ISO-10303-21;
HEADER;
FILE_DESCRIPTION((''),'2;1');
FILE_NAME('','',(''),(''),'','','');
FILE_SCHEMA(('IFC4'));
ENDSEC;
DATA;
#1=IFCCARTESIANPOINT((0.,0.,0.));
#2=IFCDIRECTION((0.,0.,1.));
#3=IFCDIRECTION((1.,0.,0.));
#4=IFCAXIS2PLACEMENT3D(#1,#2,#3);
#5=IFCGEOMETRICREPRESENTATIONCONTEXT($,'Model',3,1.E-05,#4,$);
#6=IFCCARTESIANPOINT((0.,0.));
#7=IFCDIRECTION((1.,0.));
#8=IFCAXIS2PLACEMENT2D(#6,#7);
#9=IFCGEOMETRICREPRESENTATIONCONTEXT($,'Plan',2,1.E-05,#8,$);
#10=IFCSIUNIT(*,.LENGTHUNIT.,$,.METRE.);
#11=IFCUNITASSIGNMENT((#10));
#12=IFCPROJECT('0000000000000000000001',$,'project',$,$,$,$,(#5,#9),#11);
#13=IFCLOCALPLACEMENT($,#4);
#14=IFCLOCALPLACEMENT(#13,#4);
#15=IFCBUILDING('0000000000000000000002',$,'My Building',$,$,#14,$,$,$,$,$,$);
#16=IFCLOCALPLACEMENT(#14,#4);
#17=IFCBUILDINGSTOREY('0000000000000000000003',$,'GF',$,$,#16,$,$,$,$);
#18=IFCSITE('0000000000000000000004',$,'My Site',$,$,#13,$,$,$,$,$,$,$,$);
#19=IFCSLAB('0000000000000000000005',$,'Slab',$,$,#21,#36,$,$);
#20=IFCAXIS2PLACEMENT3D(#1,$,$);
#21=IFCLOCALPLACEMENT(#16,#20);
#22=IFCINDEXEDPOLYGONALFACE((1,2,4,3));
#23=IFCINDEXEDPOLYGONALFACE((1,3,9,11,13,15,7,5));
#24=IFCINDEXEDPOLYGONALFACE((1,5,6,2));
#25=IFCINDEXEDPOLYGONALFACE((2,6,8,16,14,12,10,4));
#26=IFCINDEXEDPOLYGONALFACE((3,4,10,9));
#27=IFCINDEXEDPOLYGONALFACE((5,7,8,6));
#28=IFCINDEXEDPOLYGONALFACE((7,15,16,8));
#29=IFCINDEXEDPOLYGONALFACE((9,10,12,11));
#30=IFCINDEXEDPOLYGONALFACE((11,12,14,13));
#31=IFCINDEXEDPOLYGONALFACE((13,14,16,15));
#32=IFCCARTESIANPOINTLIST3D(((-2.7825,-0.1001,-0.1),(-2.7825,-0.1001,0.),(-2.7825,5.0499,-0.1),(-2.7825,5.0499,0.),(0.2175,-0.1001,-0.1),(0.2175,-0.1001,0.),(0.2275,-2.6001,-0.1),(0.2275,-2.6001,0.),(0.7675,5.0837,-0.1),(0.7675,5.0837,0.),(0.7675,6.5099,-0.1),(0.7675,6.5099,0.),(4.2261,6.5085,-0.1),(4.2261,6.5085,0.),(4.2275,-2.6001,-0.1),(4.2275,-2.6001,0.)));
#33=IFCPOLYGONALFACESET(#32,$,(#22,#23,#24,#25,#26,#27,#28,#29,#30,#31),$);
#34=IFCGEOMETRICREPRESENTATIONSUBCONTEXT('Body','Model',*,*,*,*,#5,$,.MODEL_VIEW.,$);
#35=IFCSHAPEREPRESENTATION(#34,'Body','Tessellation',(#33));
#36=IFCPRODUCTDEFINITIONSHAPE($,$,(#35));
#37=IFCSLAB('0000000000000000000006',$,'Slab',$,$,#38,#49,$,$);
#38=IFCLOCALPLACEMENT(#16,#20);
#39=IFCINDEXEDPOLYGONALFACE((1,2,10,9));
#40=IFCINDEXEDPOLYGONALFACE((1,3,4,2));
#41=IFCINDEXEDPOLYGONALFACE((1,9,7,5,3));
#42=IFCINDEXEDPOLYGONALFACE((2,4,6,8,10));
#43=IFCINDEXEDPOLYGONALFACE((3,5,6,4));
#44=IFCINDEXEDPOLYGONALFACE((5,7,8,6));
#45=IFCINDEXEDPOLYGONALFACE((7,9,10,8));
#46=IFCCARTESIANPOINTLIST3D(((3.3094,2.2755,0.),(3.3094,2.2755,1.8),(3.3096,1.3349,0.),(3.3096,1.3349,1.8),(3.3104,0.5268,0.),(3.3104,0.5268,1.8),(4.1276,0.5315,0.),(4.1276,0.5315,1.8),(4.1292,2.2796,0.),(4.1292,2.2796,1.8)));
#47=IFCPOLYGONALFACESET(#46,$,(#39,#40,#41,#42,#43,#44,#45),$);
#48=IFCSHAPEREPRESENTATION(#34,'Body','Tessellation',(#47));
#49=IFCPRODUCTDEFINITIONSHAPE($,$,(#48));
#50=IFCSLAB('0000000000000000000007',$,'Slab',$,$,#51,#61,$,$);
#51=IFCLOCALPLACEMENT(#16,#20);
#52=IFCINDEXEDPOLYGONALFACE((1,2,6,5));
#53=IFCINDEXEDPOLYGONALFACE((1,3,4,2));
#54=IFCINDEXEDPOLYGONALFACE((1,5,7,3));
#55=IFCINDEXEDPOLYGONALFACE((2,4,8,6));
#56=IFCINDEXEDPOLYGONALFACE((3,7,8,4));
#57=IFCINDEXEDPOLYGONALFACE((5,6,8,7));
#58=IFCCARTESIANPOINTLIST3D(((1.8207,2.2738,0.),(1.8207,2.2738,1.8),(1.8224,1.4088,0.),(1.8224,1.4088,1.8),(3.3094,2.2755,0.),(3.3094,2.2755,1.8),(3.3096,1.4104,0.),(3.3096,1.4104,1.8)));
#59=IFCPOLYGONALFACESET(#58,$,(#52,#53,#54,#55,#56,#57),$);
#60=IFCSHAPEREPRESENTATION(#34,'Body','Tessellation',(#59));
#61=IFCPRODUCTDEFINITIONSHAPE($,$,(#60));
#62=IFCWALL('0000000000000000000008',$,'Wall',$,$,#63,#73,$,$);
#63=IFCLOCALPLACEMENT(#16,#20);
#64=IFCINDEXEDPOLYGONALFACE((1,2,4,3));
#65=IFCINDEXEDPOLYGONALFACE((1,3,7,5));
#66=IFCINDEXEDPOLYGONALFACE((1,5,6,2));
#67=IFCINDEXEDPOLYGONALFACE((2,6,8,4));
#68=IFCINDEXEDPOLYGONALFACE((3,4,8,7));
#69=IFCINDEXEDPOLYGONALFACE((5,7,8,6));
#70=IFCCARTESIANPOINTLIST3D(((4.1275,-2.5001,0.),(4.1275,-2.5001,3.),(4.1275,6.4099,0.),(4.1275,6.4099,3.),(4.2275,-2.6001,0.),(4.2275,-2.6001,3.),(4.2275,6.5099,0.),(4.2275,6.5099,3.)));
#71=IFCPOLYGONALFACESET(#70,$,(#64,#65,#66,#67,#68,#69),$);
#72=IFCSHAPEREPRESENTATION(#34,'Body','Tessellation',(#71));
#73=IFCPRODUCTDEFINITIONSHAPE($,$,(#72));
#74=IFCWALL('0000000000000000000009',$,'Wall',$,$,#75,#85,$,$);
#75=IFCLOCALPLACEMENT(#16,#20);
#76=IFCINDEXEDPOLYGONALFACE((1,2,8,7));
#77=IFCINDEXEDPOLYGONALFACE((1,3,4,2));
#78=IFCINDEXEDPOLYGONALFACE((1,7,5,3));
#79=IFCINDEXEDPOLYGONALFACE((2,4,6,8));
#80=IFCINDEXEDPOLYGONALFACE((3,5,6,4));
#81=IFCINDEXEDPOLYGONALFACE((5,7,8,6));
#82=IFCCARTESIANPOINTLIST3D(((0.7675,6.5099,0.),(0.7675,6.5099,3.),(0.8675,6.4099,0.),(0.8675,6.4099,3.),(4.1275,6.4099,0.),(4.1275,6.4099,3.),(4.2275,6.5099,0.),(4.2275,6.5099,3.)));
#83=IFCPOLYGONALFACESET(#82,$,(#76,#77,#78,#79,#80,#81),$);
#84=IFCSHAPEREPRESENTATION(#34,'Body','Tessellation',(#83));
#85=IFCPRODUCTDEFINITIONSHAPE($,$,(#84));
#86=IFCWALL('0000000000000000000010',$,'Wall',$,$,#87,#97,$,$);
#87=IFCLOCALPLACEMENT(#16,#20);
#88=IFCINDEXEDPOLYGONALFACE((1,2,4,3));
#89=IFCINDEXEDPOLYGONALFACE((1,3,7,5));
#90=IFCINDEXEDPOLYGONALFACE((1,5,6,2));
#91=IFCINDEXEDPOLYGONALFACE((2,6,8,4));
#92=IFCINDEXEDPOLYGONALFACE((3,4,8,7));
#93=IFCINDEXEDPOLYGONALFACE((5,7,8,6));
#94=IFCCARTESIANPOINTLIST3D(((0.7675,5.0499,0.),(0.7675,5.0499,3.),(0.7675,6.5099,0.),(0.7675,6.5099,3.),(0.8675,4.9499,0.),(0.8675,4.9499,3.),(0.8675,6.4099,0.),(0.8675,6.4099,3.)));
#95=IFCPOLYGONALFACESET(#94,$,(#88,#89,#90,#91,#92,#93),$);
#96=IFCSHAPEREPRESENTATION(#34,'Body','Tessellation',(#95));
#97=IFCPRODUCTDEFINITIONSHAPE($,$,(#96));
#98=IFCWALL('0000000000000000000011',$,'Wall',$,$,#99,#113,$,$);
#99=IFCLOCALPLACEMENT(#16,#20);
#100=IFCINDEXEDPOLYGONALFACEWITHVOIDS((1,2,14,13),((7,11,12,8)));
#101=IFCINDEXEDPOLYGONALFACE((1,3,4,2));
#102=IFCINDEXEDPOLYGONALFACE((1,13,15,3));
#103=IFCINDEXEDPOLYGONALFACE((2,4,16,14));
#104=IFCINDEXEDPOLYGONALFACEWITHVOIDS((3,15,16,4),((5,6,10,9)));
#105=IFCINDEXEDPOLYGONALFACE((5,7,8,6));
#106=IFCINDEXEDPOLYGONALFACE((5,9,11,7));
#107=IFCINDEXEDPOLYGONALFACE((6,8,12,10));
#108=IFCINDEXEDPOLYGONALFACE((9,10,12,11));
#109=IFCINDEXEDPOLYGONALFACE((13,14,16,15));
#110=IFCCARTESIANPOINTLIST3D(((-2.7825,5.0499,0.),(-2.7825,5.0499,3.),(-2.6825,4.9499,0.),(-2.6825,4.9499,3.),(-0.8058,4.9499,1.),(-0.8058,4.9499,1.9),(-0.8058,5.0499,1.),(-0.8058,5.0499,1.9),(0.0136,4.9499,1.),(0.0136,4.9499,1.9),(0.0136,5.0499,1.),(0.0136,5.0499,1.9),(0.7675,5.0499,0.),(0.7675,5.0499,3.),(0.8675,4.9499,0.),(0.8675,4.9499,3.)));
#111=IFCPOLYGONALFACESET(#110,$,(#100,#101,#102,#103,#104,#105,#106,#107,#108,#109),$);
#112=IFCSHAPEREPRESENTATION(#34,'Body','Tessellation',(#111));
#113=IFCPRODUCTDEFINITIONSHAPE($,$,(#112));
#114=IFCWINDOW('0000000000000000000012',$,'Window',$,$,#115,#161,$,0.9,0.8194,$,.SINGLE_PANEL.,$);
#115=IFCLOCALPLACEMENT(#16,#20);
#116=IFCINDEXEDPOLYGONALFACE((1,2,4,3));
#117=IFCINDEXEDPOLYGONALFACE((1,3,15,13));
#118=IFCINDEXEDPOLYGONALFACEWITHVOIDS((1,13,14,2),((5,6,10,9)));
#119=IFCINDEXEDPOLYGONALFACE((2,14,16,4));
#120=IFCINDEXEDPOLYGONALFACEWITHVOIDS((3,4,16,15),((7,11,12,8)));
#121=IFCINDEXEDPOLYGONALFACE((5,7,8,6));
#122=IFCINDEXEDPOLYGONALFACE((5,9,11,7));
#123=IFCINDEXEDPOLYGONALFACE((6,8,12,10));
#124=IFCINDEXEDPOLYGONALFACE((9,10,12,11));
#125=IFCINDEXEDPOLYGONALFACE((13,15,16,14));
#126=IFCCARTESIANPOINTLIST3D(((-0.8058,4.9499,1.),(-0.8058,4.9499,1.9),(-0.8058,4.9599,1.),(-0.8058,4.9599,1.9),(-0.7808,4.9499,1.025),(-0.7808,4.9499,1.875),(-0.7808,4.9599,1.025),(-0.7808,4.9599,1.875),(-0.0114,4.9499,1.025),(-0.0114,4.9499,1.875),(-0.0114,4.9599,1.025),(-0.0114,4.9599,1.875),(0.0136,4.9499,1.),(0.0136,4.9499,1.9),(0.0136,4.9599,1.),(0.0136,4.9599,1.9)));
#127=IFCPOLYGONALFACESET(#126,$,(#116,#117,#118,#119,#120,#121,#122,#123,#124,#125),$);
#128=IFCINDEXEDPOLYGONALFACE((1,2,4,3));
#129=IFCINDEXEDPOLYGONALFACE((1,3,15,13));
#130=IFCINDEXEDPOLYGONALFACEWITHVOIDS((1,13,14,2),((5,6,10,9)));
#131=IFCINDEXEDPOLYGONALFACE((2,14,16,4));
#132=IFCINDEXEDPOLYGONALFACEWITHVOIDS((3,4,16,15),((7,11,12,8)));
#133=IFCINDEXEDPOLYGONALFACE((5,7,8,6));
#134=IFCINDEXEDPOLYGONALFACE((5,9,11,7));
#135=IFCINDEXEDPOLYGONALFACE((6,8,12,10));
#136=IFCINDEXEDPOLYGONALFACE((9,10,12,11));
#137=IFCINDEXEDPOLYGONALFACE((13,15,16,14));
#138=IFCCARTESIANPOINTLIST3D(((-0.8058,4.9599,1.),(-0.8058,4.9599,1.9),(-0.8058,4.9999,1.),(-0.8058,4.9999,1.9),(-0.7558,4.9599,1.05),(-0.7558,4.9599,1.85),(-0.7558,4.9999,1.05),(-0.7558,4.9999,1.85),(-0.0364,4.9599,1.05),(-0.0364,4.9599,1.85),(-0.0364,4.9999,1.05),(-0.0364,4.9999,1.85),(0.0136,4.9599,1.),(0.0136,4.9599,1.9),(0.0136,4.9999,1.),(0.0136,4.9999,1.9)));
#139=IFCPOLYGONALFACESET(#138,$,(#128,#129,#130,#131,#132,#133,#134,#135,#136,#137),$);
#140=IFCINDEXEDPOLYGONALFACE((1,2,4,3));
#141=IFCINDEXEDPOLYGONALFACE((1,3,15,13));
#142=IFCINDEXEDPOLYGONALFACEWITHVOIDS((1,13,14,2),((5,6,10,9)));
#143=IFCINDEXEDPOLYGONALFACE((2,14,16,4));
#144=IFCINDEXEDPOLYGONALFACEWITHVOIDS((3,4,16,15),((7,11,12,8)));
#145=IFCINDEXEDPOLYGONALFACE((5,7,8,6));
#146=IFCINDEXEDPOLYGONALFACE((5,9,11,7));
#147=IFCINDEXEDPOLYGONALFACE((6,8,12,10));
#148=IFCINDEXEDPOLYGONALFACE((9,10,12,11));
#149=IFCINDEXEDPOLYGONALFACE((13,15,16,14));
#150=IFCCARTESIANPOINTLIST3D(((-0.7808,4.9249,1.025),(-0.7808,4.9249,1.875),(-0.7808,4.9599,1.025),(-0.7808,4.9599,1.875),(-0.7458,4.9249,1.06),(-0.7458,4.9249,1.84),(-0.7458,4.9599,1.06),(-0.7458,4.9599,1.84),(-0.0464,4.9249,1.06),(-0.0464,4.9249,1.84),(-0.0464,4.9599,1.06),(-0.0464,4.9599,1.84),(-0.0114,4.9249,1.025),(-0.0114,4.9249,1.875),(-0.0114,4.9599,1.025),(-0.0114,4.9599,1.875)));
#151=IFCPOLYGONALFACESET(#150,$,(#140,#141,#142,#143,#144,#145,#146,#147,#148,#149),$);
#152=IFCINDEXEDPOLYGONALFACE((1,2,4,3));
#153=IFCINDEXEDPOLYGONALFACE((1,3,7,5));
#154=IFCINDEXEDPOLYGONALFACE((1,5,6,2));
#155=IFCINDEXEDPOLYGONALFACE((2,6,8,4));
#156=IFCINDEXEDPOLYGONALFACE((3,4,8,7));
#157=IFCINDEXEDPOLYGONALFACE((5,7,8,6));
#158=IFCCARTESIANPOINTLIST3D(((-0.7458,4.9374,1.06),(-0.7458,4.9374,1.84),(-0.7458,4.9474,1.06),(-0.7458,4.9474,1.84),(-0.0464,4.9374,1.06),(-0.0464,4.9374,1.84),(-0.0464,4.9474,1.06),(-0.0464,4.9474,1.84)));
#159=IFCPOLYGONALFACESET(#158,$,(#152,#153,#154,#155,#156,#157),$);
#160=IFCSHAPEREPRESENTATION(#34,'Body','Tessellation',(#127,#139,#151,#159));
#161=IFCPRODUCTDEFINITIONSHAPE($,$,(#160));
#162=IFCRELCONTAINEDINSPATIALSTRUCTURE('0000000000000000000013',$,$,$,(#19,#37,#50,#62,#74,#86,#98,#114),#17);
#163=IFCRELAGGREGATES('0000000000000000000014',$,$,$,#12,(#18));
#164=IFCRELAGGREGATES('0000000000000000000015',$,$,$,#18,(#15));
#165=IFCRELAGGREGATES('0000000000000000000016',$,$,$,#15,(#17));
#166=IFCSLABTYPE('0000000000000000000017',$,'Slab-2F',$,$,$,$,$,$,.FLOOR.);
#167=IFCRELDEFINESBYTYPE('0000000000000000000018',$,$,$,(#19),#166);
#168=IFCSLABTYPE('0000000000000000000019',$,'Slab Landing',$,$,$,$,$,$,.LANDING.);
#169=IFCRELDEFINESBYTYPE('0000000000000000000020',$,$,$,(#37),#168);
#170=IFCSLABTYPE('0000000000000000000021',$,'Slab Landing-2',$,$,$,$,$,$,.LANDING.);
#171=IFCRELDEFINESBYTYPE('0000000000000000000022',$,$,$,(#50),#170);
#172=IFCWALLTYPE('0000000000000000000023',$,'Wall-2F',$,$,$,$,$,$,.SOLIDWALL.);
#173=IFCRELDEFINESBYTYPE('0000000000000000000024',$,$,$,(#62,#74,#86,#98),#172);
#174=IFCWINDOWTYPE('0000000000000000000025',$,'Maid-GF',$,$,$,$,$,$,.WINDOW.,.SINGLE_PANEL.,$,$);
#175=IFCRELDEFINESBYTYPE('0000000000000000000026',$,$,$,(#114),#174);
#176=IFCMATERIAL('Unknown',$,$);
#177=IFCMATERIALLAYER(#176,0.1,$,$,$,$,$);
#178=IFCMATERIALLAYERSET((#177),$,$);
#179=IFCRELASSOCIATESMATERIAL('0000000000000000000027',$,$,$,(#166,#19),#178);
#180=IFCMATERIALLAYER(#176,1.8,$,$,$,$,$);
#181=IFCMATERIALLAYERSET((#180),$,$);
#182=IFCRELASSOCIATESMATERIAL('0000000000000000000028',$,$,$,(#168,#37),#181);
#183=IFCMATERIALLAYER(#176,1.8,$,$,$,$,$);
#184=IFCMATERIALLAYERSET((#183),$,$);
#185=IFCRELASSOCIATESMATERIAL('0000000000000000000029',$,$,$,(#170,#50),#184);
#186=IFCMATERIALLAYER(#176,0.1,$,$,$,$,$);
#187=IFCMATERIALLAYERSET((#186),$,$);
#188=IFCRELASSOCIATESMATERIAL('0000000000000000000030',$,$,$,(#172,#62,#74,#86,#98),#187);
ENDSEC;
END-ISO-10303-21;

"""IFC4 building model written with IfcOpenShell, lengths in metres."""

from ifc_helpers import new_model, entity, si_unit, frame, origin_with_axes, origin_2d_with_axis, place, context, subcontext, project, spatial, line, indexed_curve, outline, extrude, shape, source, transform, mapped, material, layer, layer_set, layer_usage, type_object, type_shapes, element, fill, save


model = new_model("IFC4")

# Units and contexts
model_context = context("Model", 3, precision=1e-05, world=origin_with_axes())
plan_context = context("Plan", 2, precision=1e-05, world=origin_2d_with_axis())
body_context_1 = subcontext(model_context, "Body", "Model", "MODEL_VIEW")
body_context_2 = subcontext(plan_context, "Body", "Plan", "PLAN_VIEW")
ifc_project = project(units=[si_unit("LENGTHUNIT", "METRE")], contexts=[model_context, plan_context])

# Site, building, storey
site_placement = place(None, origin_with_axes())
site = spatial("IfcSite", under=ifc_project, at=site_placement, Name="My Site")
building_placement = place(site_placement, origin_with_axes())
building = spatial("IfcBuilding", under=site, at=building_placement, Name="My Building")
storey_placement = place(building_placement, origin_with_axes())
storey = spatial("IfcBuildingStorey", under=building, at=storey_placement, Name="GF")

# Slabs
ifc_material_1 = material(Name="Unknown")
ifc_layer_1 = layer(ifc_material_1, 0.1)
ifc_layer_set_1 = layer_set([ifc_layer_1])
ifc_layer_usage_1 = layer_usage(ifc_layer_set_1, "AXIS3", "POSITIVE", -0.1)
slab_type_1 = type_object("IfcSlabType", Name="Slab-2F", PredefinedType="FLOOR", material=ifc_layer_set_1)
slab_1_placement = place(storey_placement, frame((4.2275, -2.6001, 0.0), z_axis=(0.0, 0.0, 1.0), x_axis=(1.0, 0.0, 0.0)))
element("IfcSlab", 1, at=slab_1_placement, inside=storey, type_object=slab_type_1, material=ifc_layer_usage_1, Name="Slab", context=body_context_1, shape_type="SweptSolid", body=[
    extrude(outline(indexed_curve([(0.0, 0.0), (-0.0014, 9.1086), (-3.46, 9.11), (-3.46, 7.6838), (-7.01, 7.65), (-7.01, 2.5), (-4.01, 2.5), (-4.0, 0.0), (0.0, 0.0)])), frame((0.0, 0.0, -0.1), z_axis=(0.0, 0.0, 1.0), x_axis=(1.0, 0.0, 0.0)), (0.0, 0.0, 1.0), 0.1),
])
ifc_layer_2 = layer(ifc_material_1, 1.8)
ifc_layer_set_2 = layer_set([ifc_layer_2])
ifc_layer_usage_2 = layer_usage(ifc_layer_set_2, "AXIS3", "POSITIVE", -0.1)
slab_type_2 = type_object("IfcSlabType", Name="Slab Landing", PredefinedType="LANDING", material=ifc_layer_set_2)
slab_2_placement = place(storey_placement, frame((3.3096, 1.3349, 0.1), z_axis=(0.0, 0.0, 1.0), x_axis=(1.0, 0.0, 0.0)))
element("IfcSlab", 2, at=slab_2_placement, inside=storey, type_object=slab_type_2, material=ifc_layer_usage_2, Name="Slab", context=body_context_1, shape_type="SweptSolid", body=[
    extrude(outline(indexed_curve([(0.0, 0.0), (0.0008, -0.8081), (0.818, -0.8034), (0.8196, 0.9447), (-0.0002, 0.9407), (0.0, 0.0)])), frame((0.0, 0.0, -0.1), z_axis=(0.0, 0.0, 1.0), x_axis=(1.0, 0.0, 0.0)), (0.0, 0.0, 1.0), 1.8),
])
ifc_layer_3 = layer(ifc_material_1, 1.8)
ifc_layer_set_3 = layer_set([ifc_layer_3])
ifc_layer_usage_3 = layer_usage(ifc_layer_set_3, "AXIS3", "POSITIVE", -1.8)
slab_type_3 = type_object("IfcSlabType", Name="Slab Landing-2", PredefinedType="LANDING", material=ifc_layer_set_3)
slab_3_placement = place(storey_placement, frame((3.3094, 2.2755, 1.8), z_axis=(0.0, 0.0, 1.0), x_axis=(1.0, 0.0, 0.0)))
element("IfcSlab", 3, at=slab_3_placement, inside=storey, type_object=slab_type_3, material=ifc_layer_usage_3, Name="Slab", context=body_context_1, shape_type="SweptSolid", body=[
    extrude(outline(indexed_curve([(0.0, 0.0), (0.0002, -0.8651), (-1.487, -0.8667), (-1.4887, -0.0017), (0.0, 0.0)])), frame((0.0, 0.0, -1.8), z_axis=(0.0, 0.0, 1.0), x_axis=(1.0, 0.0, 0.0)), (0.0, 0.0, 1.0), 1.8),
])

# Shared definitions
ifc_layer_4 = layer(ifc_material_1, 0.1)
ifc_layer_set_4 = layer_set([ifc_layer_4])
wall_type = type_object("IfcWallType", Name="Wall-2F", PredefinedType="SOLIDWALL", material=ifc_layer_set_4)

# Walls
ifc_layer_usage_4 = layer_usage(ifc_layer_set_4, "AXIS2", "POSITIVE", 0.0)
wall_1_placement = place(storey_placement, frame((4.2275, -2.6001, 0.0), z_axis=(0.0, 0.0, 1.0), x_axis=(0.0, 1.0, 0.0)))
element("IfcWall", 4, at=wall_1_placement, inside=storey, type_object=wall_type, material=ifc_layer_usage_4, Name="Wall", context=body_context_1, shape_type="SweptSolid", body=[
    extrude(outline(indexed_curve([(0.0, 0.0), (0.1, 0.1), (9.01, 0.1), (9.11, 0.0)], segments=[line(1, 2, 3, 4, 1)])), origin_with_axes(), (0.0, 0.0, 1.0), 3.0),
])
ifc_layer_usage_5 = layer_usage(ifc_layer_set_4, "AXIS2", "POSITIVE", 0.0)
wall_2_placement = place(storey_placement, frame((4.2275, 6.5099, 0.0), z_axis=(0.0, 0.0, 1.0), x_axis=(-1.0, 0.0, 0.0)))
element("IfcWall", 5, at=wall_2_placement, inside=storey, type_object=wall_type, material=ifc_layer_usage_5, Name="Wall", context=body_context_1, shape_type="SweptSolid", body=[
    extrude(outline(indexed_curve([(0.0, 0.0), (0.1, 0.1), (3.36, 0.1), (3.46, 0.0)], segments=[line(1, 2, 3, 4, 1)])), origin_with_axes(), (0.0, 0.0, 1.0), 3.0),
])
ifc_layer_usage_6 = layer_usage(ifc_layer_set_4, "AXIS2", "POSITIVE", 0.0)
wall_3_placement = place(storey_placement, frame((0.7675, 6.5099, 0.0), z_axis=(0.0, 0.0, 1.0), x_axis=(0.0, -1.0, 0.0)))
element("IfcWall", 6, at=wall_3_placement, inside=storey, type_object=wall_type, material=ifc_layer_usage_6, Name="Wall", context=body_context_1, shape_type="SweptSolid", body=[
    extrude(outline(indexed_curve([(0.0, 0.0), (0.1, 0.1), (1.56, 0.1), (1.46, 0.0)], segments=[line(1, 2, 3, 4, 1)])), origin_with_axes(), (0.0, 0.0, 1.0), 3.0),
])

# Wall, opening, window
ifc_layer_usage_7 = layer_usage(ifc_layer_set_4, "AXIS2", "POSITIVE", 0.0)
wall_4_placement = place(storey_placement, frame((0.7675, 5.0499, 0.0), z_axis=(0.0, 0.0, 1.0), x_axis=(-1.0, 0.0, 0.0)))
wall_4 = element("IfcWall", 7, at=wall_4_placement, inside=storey, type_object=wall_type, material=ifc_layer_usage_7, Name="Wall", context=body_context_1, shape_type="SweptSolid", body=[
    extrude(outline(indexed_curve([(0.0, 0.0), (-0.1, 0.1), (3.45, 0.1), (3.55, 0.0)], segments=[line(1, 2, 3, 4, 1)])), origin_with_axes(), (0.0, 0.0, 1.0), 3.0),
])
shared_shape_1 = source(origin_with_axes(), body_context_1, "Body", "SweptSolid", [
    extrude(outline(indexed_curve([(0.0, 0.0), (0.8194, 0.0), (0.8194, 0.9), (0.0, 0.9)], segments=[line(1, 2, 3, 4, 1)])), frame((0.0, -0.6, 0.0), z_axis=(0.0, -1.0, 0.0), x_axis=(1.0, 0.0, 0.0)), (0.0, 0.0, -1.0), 1.2),
])
opening_1_placement = place(wall_4_placement, frame((0.7539, 0.0, 1.0), z_axis=(0.0, 0.0, 1.0), x_axis=(1.0, 0.0, 0.0)))
opening_1 = element("IfcOpeningElement", 8, at=opening_1_placement, cuts=wall_4, PredefinedType="OPENING", context=body_context_1, shape_type="MappedRepresentation", body=[
    mapped(shared_shape_1, transform((0.0, 0.0, 0.0), x_axis=(1.0, 0.0, 0.0), y_axis=(0.0, 1.0, 0.0), z_axis=(0.0, 0.0, 1.0), scale=1.0)),
])
window_type_1 = type_object("IfcWindowType", Name="Maid-GF", PartitioningType="SINGLE_PANEL", PredefinedType="WINDOW")
shared_shape_2 = source(origin_with_axes(), body_context_1, "Body", "SweptSolid", [
    extrude(outline(indexed_curve([(0.0, 0.0), (0.8194, 0.0), (0.8194, 0.9), (0.0, 0.9)], segments=[line(1, 2, 3, 4, 1)]), holes=[indexed_curve([(0.025, 0.025), (0.7944, 0.025), (0.7944, 0.875), (0.025, 0.875)], segments=[line(1, 2, 3, 4, 1)])]), frame((0.0, 0.09, 0.0), z_axis=(0.0, -1.0, 0.0), x_axis=(1.0, 0.0, 0.0)), (0.0, 0.0, -1.0), 0.01),
    extrude(outline(indexed_curve([(0.0, 0.0), (0.8194, 0.0), (0.8194, 0.9), (0.0, 0.9)], segments=[line(1, 2, 3, 4, 1)]), holes=[indexed_curve([(0.05, 0.05), (0.7694, 0.05), (0.7694, 0.85), (0.05, 0.85)], segments=[line(1, 2, 3, 4, 1)])]), frame((0.0, 0.05, 0.0), z_axis=(0.0, -1.0, 0.0), x_axis=(1.0, 0.0, 0.0)), (0.0, 0.0, -1.0), 0.04),
    extrude(outline(indexed_curve([(0.0, 0.0), (0.7694, 0.0), (0.7694, 0.85), (0.0, 0.85)], segments=[line(1, 2, 3, 4, 1)]), holes=[indexed_curve([(0.035, 0.035), (0.7344, 0.035), (0.7344, 0.815), (0.035, 0.815)], segments=[line(1, 2, 3, 4, 1)])]), frame((0.025, 0.09, 0.025), z_axis=(0.0, -1.0, 0.0), x_axis=(1.0, 0.0, 0.0)), (0.0, 0.0, -1.0), 0.035),
    extrude(outline(indexed_curve([(0.035, 0.035), (0.7344, 0.035), (0.7344, 0.815), (0.035, 0.815)], segments=[line(1, 2, 3, 4, 1)])), frame((0.025, 0.1025, 0.025), z_axis=(0.0, -1.0, 0.0), x_axis=(1.0, 0.0, 0.0)), (0.0, 0.0, -1.0), 0.01),
])
shared_shape_3 = source(origin_with_axes(), body_context_2, "Body", "Curve2D", [
    entity("IfcIndexedPolyCurve", entity("IfcCartesianPointList2D", [[0.05, 0.05], [0.7694, 0.05]])),
    entity("IfcIndexedPolyCurve", entity("IfcCartesianPointList2D", [[0.0, 0.1], [0.025, 0.1], [0.025, 0.09], [0.05, 0.09], [0.05, 0.05], [0.0, 0.05]]), [entity("IfcLineIndex", [1, 2, 3, 4, 5, 6, 1])]),
    entity("IfcIndexedPolyCurve", entity("IfcCartesianPointList2D", [[0.8194, 0.1], [0.7944, 0.1], [0.7944, 0.09], [0.7694, 0.09], [0.7694, 0.05], [0.8194, 0.05]]), [entity("IfcLineIndex", [1, 2, 3, 4, 5, 6, 1])]),
    entity("IfcIndexedPolyCurve", entity("IfcCartesianPointList2D", [[0.025, 0.09], [0.06, 0.09], [0.06, 0.125], [0.025, 0.125]]), [entity("IfcLineIndex", [1, 2, 3, 4, 1])]),
    entity("IfcIndexedPolyCurve", entity("IfcCartesianPointList2D", [[0.7944, 0.09], [0.7594, 0.09], [0.7594, 0.125], [0.7944, 0.125]]), [entity("IfcLineIndex", [1, 2, 3, 4, 1])]),
    entity("IfcIndexedPolyCurve", entity("IfcCartesianPointList2D", [[0.06, 0.09], [0.7594, 0.09]])),
    entity("IfcIndexedPolyCurve", entity("IfcCartesianPointList2D", [[0.06, 0.125], [0.7594, 0.125]])),
    entity("IfcIndexedPolyCurve", entity("IfcCartesianPointList2D", [[0.06, 0.1075], [0.7594, 0.1075]])),
])
type_shapes(window_type_1, [shared_shape_2, shared_shape_3])
window_1_placement = place(opening_1_placement, frame((0.0, 0.0, 0.0), z_axis=(0.0, 0.0, 1.0), x_axis=(1.0, 0.0, 0.0)))
window_1 = element("IfcWindow", 9, at=window_1_placement, inside=storey, type_object=window_type_1, Name="Window", OverallHeight=0.9, OverallWidth=0.8194, PartitioningType="SINGLE_PANEL", shapes=[
    shape(body_context_1, "Body", "MappedRepresentation", [mapped(shared_shape_2, transform((0.0, 0.0, 0.0), x_axis=(1.0, 0.0, 0.0), y_axis=(0.0, 1.0, 0.0), z_axis=(0.0, 0.0, 1.0), scale=1.0))]),
    shape(body_context_2, "Body", "MappedRepresentation", [mapped(shared_shape_3, transform((0.0, 0.0, 0.0), x_axis=(1.0, 0.0, 0.0), y_axis=(0.0, 1.0, 0.0), z_axis=(0.0, 0.0, 1.0), scale=1.0))]),
])
fill(opening_1, window_1)

save(model, "model.ifc")
